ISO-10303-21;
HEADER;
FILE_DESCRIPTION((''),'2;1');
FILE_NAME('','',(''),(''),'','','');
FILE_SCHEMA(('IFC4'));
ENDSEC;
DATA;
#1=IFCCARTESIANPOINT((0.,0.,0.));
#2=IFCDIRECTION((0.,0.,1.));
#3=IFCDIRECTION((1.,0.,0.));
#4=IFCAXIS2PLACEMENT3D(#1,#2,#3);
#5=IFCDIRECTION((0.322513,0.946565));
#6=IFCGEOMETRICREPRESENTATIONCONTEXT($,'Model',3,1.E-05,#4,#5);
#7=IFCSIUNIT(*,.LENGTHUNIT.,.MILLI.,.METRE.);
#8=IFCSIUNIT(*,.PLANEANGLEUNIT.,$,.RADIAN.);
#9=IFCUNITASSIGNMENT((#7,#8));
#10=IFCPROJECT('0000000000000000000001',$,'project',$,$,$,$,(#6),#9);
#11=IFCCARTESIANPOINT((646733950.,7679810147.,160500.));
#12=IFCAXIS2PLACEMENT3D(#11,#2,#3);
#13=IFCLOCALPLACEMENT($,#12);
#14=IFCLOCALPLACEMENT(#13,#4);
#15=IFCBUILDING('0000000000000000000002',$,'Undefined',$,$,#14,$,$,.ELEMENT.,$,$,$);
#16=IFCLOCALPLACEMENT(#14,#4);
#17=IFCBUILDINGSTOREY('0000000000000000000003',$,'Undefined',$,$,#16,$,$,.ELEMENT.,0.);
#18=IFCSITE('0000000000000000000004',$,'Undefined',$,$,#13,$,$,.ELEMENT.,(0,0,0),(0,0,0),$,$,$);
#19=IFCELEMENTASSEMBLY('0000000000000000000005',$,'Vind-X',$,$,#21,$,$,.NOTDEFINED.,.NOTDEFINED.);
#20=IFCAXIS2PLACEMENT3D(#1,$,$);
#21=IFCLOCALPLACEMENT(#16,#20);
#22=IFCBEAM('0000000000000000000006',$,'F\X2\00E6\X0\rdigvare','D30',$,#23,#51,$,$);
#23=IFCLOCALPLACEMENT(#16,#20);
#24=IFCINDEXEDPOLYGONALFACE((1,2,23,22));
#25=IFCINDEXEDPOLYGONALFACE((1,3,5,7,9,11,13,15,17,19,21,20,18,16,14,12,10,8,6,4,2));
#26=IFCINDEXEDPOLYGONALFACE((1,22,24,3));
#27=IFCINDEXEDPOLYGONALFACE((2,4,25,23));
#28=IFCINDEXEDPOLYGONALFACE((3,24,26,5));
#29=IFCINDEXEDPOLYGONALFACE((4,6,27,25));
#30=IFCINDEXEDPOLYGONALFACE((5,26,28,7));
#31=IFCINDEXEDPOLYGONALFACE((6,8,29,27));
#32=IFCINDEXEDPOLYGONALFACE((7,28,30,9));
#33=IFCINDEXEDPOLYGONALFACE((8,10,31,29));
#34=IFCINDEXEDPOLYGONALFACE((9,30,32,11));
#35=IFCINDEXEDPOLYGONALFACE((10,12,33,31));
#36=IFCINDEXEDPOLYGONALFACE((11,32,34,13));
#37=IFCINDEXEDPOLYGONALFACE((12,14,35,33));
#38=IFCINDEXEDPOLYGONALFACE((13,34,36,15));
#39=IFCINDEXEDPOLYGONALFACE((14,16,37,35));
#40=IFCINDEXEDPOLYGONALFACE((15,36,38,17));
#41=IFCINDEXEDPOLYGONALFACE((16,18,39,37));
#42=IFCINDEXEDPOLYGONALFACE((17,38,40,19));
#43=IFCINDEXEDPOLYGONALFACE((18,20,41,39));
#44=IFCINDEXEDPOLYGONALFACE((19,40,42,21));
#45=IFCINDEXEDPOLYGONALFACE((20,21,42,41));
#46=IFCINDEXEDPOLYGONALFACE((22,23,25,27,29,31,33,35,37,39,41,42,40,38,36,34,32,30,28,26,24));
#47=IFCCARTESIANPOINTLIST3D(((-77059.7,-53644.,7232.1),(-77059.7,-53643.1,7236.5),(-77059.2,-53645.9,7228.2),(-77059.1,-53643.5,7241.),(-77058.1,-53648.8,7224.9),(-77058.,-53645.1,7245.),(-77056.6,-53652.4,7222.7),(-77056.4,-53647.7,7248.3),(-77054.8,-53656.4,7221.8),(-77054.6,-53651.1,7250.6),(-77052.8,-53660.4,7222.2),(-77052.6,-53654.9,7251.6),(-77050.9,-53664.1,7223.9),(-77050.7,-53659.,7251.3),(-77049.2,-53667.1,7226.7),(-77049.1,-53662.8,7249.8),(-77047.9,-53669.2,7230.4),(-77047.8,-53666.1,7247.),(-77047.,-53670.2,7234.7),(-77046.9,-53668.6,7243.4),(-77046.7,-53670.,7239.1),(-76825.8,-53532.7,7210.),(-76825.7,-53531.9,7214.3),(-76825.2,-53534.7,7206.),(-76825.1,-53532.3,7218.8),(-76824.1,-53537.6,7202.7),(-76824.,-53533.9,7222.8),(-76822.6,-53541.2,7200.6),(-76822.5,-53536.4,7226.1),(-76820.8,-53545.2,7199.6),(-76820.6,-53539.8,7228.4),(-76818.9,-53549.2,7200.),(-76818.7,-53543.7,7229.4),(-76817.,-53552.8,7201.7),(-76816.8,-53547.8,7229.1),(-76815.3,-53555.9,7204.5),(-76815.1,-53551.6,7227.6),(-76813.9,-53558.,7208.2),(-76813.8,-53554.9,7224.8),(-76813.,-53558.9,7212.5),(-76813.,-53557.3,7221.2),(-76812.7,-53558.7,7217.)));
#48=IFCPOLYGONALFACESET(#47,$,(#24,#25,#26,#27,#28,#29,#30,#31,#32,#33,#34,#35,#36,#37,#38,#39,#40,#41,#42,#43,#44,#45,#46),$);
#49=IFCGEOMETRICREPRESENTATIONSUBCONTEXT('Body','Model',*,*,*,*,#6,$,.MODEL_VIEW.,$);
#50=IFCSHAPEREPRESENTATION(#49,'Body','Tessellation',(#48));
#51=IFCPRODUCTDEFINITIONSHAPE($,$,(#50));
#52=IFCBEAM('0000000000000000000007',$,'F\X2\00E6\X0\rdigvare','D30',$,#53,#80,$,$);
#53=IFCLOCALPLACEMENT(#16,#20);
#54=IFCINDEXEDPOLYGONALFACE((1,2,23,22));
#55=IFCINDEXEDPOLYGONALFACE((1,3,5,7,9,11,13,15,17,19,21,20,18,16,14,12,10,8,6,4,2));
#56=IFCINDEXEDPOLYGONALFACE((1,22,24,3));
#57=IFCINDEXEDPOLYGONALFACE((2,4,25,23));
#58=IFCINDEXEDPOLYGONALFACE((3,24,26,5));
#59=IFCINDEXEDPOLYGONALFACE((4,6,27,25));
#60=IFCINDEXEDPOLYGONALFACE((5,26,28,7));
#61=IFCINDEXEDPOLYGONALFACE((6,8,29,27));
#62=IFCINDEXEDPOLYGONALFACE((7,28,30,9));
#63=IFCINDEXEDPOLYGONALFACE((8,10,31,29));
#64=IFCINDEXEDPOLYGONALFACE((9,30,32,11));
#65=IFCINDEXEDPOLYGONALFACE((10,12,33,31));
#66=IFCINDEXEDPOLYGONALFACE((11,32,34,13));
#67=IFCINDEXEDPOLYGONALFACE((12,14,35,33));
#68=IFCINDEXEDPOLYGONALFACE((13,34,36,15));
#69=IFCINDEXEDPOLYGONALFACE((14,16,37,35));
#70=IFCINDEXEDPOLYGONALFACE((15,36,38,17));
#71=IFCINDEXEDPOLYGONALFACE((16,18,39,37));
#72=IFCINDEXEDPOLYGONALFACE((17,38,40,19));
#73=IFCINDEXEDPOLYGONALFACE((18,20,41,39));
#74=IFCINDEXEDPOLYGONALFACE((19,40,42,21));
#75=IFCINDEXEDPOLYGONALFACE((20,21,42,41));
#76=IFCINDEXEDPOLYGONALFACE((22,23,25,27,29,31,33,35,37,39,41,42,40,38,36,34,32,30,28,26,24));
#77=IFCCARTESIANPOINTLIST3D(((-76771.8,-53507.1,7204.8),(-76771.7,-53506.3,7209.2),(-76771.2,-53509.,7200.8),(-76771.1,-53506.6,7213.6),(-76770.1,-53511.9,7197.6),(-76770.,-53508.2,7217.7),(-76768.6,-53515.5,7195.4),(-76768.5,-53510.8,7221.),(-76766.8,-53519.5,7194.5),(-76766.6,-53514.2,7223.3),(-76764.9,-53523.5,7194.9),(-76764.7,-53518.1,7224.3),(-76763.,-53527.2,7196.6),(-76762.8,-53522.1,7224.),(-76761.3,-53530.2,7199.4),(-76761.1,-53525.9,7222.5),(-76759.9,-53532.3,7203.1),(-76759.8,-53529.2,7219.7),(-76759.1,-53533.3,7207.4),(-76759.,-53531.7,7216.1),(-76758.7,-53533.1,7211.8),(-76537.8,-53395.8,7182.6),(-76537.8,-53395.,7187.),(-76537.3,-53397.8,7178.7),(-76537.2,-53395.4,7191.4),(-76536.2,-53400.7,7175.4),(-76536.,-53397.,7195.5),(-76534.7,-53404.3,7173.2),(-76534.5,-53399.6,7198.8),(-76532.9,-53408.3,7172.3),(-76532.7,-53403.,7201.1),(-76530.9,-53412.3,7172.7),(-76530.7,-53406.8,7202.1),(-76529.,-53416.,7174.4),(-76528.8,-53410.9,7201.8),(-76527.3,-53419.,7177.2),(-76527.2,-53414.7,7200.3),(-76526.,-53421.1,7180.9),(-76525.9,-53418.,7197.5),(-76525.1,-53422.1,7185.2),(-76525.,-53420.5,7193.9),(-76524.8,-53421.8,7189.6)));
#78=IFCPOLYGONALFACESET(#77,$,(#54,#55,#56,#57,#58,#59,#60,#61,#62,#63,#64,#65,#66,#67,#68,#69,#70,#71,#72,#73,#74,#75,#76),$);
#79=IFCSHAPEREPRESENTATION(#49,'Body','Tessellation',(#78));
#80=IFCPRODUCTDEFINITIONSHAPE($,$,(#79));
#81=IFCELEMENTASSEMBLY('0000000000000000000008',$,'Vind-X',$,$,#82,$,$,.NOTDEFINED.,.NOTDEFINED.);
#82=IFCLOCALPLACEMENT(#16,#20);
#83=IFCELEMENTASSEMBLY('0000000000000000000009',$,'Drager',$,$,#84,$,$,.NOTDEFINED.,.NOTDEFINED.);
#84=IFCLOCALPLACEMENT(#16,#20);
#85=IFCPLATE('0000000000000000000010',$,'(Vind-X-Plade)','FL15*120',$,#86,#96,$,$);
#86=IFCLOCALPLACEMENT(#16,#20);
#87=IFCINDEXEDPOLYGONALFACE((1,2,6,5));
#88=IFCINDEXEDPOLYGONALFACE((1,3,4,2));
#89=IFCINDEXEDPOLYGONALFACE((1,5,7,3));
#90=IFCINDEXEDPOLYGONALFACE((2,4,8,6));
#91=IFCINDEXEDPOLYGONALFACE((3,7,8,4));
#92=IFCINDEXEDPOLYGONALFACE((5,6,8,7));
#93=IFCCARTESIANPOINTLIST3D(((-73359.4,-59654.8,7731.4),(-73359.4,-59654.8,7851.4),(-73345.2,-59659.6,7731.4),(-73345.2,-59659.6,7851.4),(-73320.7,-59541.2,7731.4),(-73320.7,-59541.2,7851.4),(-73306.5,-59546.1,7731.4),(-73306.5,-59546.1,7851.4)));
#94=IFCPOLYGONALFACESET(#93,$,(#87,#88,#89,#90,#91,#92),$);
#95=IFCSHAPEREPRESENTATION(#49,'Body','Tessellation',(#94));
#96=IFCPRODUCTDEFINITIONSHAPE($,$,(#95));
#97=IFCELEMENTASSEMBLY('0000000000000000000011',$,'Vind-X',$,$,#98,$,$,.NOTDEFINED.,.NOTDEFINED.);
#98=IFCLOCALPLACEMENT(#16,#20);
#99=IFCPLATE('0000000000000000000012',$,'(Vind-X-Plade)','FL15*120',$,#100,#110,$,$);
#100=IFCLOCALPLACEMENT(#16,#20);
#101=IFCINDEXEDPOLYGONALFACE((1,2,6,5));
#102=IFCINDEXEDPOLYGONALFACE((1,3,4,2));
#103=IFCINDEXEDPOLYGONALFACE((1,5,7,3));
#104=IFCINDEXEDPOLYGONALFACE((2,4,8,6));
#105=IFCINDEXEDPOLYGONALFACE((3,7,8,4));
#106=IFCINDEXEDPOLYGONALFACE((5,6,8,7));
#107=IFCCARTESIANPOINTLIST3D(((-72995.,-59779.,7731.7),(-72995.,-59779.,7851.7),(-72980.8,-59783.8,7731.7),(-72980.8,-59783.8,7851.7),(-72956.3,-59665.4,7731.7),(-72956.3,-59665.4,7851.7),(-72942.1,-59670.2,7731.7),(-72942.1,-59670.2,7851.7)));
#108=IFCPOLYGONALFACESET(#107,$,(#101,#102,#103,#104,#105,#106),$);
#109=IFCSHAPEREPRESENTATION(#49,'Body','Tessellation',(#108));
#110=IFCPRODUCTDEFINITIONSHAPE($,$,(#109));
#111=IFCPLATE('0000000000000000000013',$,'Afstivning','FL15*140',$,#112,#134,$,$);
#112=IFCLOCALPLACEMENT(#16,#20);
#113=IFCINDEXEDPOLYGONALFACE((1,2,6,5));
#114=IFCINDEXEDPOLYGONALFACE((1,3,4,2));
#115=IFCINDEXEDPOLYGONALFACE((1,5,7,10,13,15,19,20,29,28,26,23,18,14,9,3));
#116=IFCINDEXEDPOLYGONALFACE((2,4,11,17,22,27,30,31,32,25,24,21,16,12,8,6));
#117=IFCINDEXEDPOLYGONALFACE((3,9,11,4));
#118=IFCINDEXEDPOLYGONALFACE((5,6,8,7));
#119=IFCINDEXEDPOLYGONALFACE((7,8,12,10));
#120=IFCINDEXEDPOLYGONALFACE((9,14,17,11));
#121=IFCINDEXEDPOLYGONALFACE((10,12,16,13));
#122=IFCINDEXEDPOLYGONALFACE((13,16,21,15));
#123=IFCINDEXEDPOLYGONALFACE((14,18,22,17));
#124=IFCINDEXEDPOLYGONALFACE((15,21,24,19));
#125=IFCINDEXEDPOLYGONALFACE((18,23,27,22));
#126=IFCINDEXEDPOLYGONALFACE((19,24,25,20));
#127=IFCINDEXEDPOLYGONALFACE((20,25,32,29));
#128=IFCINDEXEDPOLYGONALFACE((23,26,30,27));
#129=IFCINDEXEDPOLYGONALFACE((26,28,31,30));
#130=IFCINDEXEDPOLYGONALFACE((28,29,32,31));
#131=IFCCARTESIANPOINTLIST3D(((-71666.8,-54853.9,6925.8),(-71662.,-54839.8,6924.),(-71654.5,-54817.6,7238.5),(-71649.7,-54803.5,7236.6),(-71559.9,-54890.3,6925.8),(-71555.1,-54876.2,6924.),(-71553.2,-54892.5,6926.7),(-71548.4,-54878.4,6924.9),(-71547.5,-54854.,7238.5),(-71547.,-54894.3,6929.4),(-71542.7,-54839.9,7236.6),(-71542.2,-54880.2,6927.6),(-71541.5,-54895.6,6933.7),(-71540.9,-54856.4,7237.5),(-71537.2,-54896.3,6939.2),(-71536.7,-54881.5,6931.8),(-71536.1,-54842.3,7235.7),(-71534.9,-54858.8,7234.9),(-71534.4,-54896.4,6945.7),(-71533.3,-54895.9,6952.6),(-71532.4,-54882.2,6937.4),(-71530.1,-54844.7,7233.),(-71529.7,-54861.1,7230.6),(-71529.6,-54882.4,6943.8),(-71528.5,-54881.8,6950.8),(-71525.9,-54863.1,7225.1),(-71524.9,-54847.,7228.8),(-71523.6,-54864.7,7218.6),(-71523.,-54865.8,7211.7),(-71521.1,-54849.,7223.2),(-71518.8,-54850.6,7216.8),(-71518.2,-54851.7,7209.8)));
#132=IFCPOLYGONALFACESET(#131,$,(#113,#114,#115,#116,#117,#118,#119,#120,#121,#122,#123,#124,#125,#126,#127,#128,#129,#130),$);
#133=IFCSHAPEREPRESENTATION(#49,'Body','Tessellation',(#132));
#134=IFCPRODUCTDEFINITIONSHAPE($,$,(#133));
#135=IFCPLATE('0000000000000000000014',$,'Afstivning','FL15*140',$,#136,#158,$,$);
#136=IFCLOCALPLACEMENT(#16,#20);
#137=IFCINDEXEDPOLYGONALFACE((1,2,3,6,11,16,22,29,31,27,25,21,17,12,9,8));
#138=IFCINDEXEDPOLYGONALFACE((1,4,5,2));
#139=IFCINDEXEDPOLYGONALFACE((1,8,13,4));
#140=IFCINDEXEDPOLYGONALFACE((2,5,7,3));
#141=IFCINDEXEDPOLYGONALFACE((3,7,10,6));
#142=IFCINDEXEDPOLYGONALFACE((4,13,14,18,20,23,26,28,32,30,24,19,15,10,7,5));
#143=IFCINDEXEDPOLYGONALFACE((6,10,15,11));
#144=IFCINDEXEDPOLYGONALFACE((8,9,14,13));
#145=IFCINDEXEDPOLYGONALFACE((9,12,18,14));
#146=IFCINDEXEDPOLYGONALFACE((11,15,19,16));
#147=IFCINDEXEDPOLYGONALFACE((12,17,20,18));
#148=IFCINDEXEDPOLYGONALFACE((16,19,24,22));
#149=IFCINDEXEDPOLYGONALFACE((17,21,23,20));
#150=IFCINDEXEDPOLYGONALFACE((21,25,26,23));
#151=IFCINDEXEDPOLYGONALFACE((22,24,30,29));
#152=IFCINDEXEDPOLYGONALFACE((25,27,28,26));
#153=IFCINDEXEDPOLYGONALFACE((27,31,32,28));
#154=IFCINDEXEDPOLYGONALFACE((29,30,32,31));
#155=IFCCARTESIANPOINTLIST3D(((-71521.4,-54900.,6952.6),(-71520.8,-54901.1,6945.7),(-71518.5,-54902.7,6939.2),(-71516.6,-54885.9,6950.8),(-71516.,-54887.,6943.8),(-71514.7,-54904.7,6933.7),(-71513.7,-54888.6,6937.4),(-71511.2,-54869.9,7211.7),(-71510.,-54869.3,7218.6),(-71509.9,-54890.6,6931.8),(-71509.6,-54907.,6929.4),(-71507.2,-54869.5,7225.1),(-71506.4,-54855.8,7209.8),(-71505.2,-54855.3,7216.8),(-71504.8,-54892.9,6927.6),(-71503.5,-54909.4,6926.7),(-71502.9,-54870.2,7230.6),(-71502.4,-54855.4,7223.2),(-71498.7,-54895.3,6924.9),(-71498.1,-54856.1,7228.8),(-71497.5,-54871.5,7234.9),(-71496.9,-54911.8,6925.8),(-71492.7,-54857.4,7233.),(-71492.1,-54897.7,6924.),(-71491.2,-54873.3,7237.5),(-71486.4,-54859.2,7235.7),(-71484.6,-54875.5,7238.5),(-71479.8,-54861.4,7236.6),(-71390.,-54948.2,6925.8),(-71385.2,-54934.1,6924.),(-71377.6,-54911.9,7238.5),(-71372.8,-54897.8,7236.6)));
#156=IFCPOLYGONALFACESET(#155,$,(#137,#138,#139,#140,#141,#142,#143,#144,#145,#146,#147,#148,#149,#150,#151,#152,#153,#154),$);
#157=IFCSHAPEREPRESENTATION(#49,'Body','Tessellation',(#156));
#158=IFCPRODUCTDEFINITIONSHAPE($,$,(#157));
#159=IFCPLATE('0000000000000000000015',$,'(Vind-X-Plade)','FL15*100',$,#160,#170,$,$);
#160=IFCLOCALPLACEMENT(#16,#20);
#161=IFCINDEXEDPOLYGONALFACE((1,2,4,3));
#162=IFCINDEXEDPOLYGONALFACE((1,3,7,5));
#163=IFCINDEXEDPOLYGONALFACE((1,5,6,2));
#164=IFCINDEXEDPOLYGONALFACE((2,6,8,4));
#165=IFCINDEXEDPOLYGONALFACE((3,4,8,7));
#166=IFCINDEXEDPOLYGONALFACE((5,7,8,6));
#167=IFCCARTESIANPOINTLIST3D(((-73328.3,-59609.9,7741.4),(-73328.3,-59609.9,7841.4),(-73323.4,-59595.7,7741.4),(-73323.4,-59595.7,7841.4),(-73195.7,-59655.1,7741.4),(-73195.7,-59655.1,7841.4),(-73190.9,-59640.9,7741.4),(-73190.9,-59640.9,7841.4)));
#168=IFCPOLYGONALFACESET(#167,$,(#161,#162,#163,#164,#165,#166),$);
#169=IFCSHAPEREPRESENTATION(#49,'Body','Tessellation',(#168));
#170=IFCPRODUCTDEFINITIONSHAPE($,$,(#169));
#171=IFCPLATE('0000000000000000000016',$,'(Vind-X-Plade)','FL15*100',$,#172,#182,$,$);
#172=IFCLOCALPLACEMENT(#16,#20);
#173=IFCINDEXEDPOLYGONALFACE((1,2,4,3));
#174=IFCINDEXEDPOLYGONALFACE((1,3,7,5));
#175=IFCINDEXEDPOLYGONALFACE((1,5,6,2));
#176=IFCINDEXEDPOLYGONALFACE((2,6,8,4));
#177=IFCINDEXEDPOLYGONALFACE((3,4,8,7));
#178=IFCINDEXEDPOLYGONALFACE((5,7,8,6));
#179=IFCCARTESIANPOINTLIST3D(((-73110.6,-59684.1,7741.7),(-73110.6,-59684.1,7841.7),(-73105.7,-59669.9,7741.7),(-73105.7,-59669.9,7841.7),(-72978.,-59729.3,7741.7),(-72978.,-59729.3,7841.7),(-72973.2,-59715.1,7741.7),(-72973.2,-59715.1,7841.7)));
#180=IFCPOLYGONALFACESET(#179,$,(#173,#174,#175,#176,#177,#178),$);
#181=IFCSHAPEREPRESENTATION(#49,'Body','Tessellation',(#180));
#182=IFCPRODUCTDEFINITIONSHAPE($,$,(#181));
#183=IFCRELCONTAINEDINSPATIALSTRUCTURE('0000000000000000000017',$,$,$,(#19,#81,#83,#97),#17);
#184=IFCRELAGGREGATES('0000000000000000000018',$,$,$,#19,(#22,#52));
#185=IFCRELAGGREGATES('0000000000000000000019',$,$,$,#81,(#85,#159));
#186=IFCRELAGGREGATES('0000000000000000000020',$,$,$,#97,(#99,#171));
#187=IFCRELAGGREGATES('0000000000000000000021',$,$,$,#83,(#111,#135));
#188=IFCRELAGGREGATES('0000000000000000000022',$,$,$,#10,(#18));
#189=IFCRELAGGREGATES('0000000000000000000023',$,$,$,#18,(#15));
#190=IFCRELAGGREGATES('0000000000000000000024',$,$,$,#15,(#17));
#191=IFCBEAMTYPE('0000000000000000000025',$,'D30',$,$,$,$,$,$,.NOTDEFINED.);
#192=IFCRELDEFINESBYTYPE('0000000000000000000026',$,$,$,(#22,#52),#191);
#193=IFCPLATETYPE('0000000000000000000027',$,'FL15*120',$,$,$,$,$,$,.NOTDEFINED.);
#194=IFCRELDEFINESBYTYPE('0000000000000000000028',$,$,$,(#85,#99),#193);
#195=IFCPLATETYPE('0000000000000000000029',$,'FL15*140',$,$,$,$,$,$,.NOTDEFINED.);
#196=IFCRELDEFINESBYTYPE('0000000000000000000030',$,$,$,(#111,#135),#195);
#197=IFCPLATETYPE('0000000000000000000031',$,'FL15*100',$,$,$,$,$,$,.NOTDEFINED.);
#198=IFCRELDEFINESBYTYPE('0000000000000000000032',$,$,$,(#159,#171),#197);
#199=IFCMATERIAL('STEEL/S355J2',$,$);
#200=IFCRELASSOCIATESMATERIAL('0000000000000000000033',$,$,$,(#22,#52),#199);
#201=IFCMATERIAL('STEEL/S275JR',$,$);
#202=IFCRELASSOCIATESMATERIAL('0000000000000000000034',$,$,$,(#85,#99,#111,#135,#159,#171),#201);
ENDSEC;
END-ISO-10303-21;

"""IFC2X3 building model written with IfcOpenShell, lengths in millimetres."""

from ifc_helpers import new_model, si_unit, direction, frame, frame_2d, origin_with_axes, origin_2d_with_axis, place, context, subcontext, project, spatial, polyline, circle_curve, parameter, trimmed, segment, composite_curve, circle, outline, extrude, material, type_object, element, aggregate, save


model = new_model("IFC2X3")

# Units and contexts
model_context = context("Model", 3, precision=1e-05, world=origin_with_axes(), true_north=direction((0.322513, 0.946565)))
body_context = subcontext(model_context, "Body", "Model", "MODEL_VIEW")
ifc_project = project(units=[si_unit("LENGTHUNIT", "METRE", prefix="MILLI"), si_unit("PLANEANGLEUNIT", "RADIAN")], contexts=[model_context])

# Site, building, storey
site_placement = place(None, frame((646733950.0, 7679810147.0, 160500.0), z_axis=(0.0, 0.0, 1.0), x_axis=(1.0, 0.0, 0.0)))
site = spatial("IfcSite", under=ifc_project, at=site_placement, Name="Undefined", CompositionType="ELEMENT", RefLatitude=(0, 0, 0), RefLongitude=(0, 0, 0))
building_placement = place(site_placement, origin_with_axes())
building = spatial("IfcBuilding", under=site, at=building_placement, Name="Undefined", CompositionType="ELEMENT")
storey_placement = place(building_placement, origin_with_axes())
storey = spatial("IfcBuildingStorey", under=building, at=storey_placement, Name="Undefined", CompositionType="ELEMENT", Elevation=0.0)

# Element assembly, beams
assembly_1_placement = place(storey_placement, origin_with_axes())
assembly_1 = element("IfcElementAssembly", 1, at=assembly_1_placement, inside=storey, Name="Vind-X", AssemblyPlace="NOTDEFINED", PredefinedType="NOTDEFINED")
ifc_material_1 = material(Name="STEEL/S355J2")
beam_type_1 = type_object("IfcBeamType", Name="D30", PredefinedType="NOTDEFINED")
beam_1_placement = place(assembly_1_placement, frame((-76819.3, -53545.5, 7214.5), z_axis=(0.434441, -0.89649, 0.08699), x_axis=(-0.899842, -0.427784, 0.085352)))
beam_1 = element("IfcBeam", 2, at=beam_1_placement, type_object=beam_type_1, material=ifc_material_1, Name="Færdigvare", Description="D30", context=body_context, shape_type="SweptSolid", body=[
    extrude(circle(Radius=15.0, at=origin_2d_with_axis()), frame((260.0, 0.0, 0.0), z_axis=(-1.0, 0.0, 0.0), x_axis=(0.0, -1.0, 0.0)), (0.0, 0.0, 1.0), 260.0),
])
beam_2_placement = place(assembly_1_placement, frame((-76531.3, -53408.6, 7187.2), z_axis=(0.434441, -0.89649, 0.08699), x_axis=(-0.899843, -0.427783, 0.085352)))
beam_2 = element("IfcBeam", 3, at=beam_2_placement, type_object=beam_type_1, material=ifc_material_1, Name="Færdigvare", Description="D30", context=body_context, shape_type="SweptSolid", body=[
    extrude(circle(Radius=15.0, at=origin_2d_with_axis()), frame((260.0, 0.0, 0.0), z_axis=(-1.0, 0.0, 0.0), x_axis=(0.0, -1.0, 0.0)), (0.0, 0.0, 1.0), 260.0),
])
aggregate(assembly_1, [beam_1, beam_2])

# Element assemblies
assembly_2_placement = place(storey_placement, origin_with_axes())
assembly_2 = element("IfcElementAssembly", 4, at=assembly_2_placement, inside=storey, Name="Vind-X", AssemblyPlace="NOTDEFINED", PredefinedType="NOTDEFINED")
assembly_3_placement = place(storey_placement, origin_with_axes())
assembly_3 = element("IfcElementAssembly", 5, at=assembly_3_placement, inside=storey, Name="Drager", AssemblyPlace="NOTDEFINED", PredefinedType="NOTDEFINED")

# Plate
ifc_material_2 = material(Name="STEEL/S275JR")
plate_type_1 = type_object("IfcPlateType", Name="FL15*120", PredefinedType="NOTDEFINED")
plate_1_placement = place(assembly_2_placement, frame((-73313.6, -59543.6, 7851.4), z_axis=(0.946565, -0.322513, 0.0), x_axis=(-0.322513, -0.946565, 0.0)))
plate_1 = element("IfcPlate", 6, at=plate_1_placement, type_object=plate_type_1, material=ifc_material_2, Name="(Vind-X-Plade)", Description="FL15*120", context=body_context, shape_type="SweptSolid", body=[
    extrude(outline(polyline([(0.0, 0.0), (120.0, 0.0), (120.0, 120.0), (0.0, 120.0), (0.0, 0.0)])), frame((0.0, 0.0, -7.5), z_axis=(0.0, 0.0, 1.0), x_axis=(1.0, 0.0, 0.0)), (0.0, 0.0, 1.0), 15.0),
])

# Element assembly, plate
assembly_4_placement = place(storey_placement, origin_with_axes())
assembly_4 = element("IfcElementAssembly", 7, at=assembly_4_placement, inside=storey, Name="Vind-X", AssemblyPlace="NOTDEFINED", PredefinedType="NOTDEFINED")
plate_2_placement = place(assembly_4_placement, frame((-72987.9, -59781.4, 7851.7), z_axis=(-0.946565, 0.322513, 0.0), x_axis=(0.322513, 0.946565, 0.0)))
plate_2 = element("IfcPlate", 8, at=plate_2_placement, type_object=plate_type_1, material=ifc_material_2, Name="(Vind-X-Plade)", Description="FL15*120", context=body_context, shape_type="SweptSolid", body=[
    extrude(outline(polyline([(0.0, 0.0), (120.0, 0.0), (120.0, 120.0), (0.0, 120.0), (0.0, 0.0)])), frame((0.0, 0.0, -7.5), z_axis=(0.0, 0.0, 1.0), x_axis=(1.0, 0.0, 0.0)), (0.0, 0.0, 1.0), 15.0),
])

# Plates
plate_type_2 = type_object("IfcPlateType", Name="FL15*140", PredefinedType="NOTDEFINED")
plate_3_placement = place(assembly_3_placement, frame((-71531.9, -54892.0, 6924.9), z_axis=(0.320109, 0.93951, -0.121869), x_axis=(-0.946565, 0.322513, 0.0)))
plate_3 = element("IfcPlate", 9, at=plate_3_placement, type_object=plate_type_2, material=ifc_material_2, Name="Afstivning", Description="FL15*140", context=body_context, shape_type="SweptSolid", body=[
    extrude(outline(composite_curve([segment(trimmed(circle_curve(frame_2d((27.0, 27.0), x_axis=(-1.0, 0.0)), 27.0), [parameter(0.0)], [parameter(1.570796)], True, "PARAMETER"), True, "CONTINUOUS"), segment(polyline([(27.0, 0.0), (140.0, 0.0), (140.0, 315.0), (27.0, 315.0)]), True, "CONTINUOUS"), segment(trimmed(circle_curve(frame_2d((27.0, 288.0), x_axis=(0.0, 1.0)), 27.0), [parameter(0.0)], [parameter(1.570796)], True, "PARAMETER"), True, "CONTINUOUS"), segment(polyline([(0.0, 288.0), (0.0, 27.0)]), True, "CONTINUOUS")], self_intersect=True)), frame((0.0, 0.0, -7.5), z_axis=(0.0, 0.0, 1.0), x_axis=(1.0, 0.0, 0.0)), (0.0, 0.0, 1.0), 15.0),
])
plate_4_placement = place(assembly_3_placement, frame((-71387.6, -54941.2, 6924.9), z_axis=(0.320109, 0.93951, -0.121869), x_axis=(-0.946565, 0.322513, 0.0)))
plate_4 = element("IfcPlate", 10, at=plate_4_placement, type_object=plate_type_2, material=ifc_material_2, Name="Afstivning", Description="FL15*140", context=body_context, shape_type="SweptSolid", body=[
    extrude(outline(composite_curve([segment(polyline([(0.0, 0.0), (113.0, 0.0)]), True, "CONTINUOUS"), segment(trimmed(circle_curve(frame_2d((113.0, 27.0), x_axis=(0.0, -1.0)), 27.0), [parameter(0.0)], [parameter(1.570796)], True, "PARAMETER"), True, "CONTINUOUS"), segment(polyline([(140.0, 27.0), (140.0, 288.0)]), True, "CONTINUOUS"), segment(trimmed(circle_curve(frame_2d((113.0, 288.0), x_axis=(1.0, 0.0)), 27.0), [parameter(0.0)], [parameter(1.570796)], True, "PARAMETER"), True, "CONTINUOUS"), segment(polyline([(113.0, 315.0), (0.0, 315.0), (0.0, 0.0)]), True, "CONTINUOUS")], self_intersect=True)), frame((0.0, 0.0, -7.5), z_axis=(0.0, 0.0, 1.0), x_axis=(1.0, 0.0, 0.0)), (0.0, 0.0, 1.0), 15.0),
])
plate_type_3 = type_object("IfcPlateType", Name="FL15*100", PredefinedType="NOTDEFINED")
plate_5_placement = place(assembly_2_placement, frame((-73193.3, -59648.0, 7741.4), z_axis=(-0.322513, -0.946565, 0.0), x_axis=(0.0, 0.0, 1.0)))
plate_5 = element("IfcPlate", 11, at=plate_5_placement, type_object=plate_type_3, material=ifc_material_2, Name="(Vind-X-Plade)", Description="FL15*100", context=body_context, shape_type="SweptSolid", body=[
    extrude(outline(polyline([(0.0, 0.0), (100.0, 0.0), (100.0, 140.0), (0.0, 140.0), (0.0, 0.0)])), frame((0.0, 0.0, -7.5), z_axis=(0.0, 0.0, 1.0), x_axis=(1.0, 0.0, 0.0)), (0.0, 0.0, 1.0), 15.0),
])
aggregate(assembly_2, [plate_1, plate_5])
plate_6_placement = place(assembly_4_placement, frame((-73108.1, -59677.0, 7741.7), z_axis=(0.322513, 0.946565, 0.0), x_axis=(0.0, 0.0, 1.0)))
plate_6 = element("IfcPlate", 12, at=plate_6_placement, type_object=plate_type_3, material=ifc_material_2, Name="(Vind-X-Plade)", Description="FL15*100", context=body_context, shape_type="SweptSolid", body=[
    extrude(outline(polyline([(0.0, 0.0), (100.0, 0.0), (100.0, 140.0), (0.0, 140.0), (0.0, 0.0)])), frame((0.0, 0.0, -7.5), z_axis=(0.0, 0.0, 1.0), x_axis=(1.0, 0.0, 0.0)), (0.0, 0.0, 1.0), 15.0),
])
aggregate(assembly_4, [plate_2, plate_6])

aggregate(assembly_3, [plate_3, plate_4])

save(model, "model.ifc")
